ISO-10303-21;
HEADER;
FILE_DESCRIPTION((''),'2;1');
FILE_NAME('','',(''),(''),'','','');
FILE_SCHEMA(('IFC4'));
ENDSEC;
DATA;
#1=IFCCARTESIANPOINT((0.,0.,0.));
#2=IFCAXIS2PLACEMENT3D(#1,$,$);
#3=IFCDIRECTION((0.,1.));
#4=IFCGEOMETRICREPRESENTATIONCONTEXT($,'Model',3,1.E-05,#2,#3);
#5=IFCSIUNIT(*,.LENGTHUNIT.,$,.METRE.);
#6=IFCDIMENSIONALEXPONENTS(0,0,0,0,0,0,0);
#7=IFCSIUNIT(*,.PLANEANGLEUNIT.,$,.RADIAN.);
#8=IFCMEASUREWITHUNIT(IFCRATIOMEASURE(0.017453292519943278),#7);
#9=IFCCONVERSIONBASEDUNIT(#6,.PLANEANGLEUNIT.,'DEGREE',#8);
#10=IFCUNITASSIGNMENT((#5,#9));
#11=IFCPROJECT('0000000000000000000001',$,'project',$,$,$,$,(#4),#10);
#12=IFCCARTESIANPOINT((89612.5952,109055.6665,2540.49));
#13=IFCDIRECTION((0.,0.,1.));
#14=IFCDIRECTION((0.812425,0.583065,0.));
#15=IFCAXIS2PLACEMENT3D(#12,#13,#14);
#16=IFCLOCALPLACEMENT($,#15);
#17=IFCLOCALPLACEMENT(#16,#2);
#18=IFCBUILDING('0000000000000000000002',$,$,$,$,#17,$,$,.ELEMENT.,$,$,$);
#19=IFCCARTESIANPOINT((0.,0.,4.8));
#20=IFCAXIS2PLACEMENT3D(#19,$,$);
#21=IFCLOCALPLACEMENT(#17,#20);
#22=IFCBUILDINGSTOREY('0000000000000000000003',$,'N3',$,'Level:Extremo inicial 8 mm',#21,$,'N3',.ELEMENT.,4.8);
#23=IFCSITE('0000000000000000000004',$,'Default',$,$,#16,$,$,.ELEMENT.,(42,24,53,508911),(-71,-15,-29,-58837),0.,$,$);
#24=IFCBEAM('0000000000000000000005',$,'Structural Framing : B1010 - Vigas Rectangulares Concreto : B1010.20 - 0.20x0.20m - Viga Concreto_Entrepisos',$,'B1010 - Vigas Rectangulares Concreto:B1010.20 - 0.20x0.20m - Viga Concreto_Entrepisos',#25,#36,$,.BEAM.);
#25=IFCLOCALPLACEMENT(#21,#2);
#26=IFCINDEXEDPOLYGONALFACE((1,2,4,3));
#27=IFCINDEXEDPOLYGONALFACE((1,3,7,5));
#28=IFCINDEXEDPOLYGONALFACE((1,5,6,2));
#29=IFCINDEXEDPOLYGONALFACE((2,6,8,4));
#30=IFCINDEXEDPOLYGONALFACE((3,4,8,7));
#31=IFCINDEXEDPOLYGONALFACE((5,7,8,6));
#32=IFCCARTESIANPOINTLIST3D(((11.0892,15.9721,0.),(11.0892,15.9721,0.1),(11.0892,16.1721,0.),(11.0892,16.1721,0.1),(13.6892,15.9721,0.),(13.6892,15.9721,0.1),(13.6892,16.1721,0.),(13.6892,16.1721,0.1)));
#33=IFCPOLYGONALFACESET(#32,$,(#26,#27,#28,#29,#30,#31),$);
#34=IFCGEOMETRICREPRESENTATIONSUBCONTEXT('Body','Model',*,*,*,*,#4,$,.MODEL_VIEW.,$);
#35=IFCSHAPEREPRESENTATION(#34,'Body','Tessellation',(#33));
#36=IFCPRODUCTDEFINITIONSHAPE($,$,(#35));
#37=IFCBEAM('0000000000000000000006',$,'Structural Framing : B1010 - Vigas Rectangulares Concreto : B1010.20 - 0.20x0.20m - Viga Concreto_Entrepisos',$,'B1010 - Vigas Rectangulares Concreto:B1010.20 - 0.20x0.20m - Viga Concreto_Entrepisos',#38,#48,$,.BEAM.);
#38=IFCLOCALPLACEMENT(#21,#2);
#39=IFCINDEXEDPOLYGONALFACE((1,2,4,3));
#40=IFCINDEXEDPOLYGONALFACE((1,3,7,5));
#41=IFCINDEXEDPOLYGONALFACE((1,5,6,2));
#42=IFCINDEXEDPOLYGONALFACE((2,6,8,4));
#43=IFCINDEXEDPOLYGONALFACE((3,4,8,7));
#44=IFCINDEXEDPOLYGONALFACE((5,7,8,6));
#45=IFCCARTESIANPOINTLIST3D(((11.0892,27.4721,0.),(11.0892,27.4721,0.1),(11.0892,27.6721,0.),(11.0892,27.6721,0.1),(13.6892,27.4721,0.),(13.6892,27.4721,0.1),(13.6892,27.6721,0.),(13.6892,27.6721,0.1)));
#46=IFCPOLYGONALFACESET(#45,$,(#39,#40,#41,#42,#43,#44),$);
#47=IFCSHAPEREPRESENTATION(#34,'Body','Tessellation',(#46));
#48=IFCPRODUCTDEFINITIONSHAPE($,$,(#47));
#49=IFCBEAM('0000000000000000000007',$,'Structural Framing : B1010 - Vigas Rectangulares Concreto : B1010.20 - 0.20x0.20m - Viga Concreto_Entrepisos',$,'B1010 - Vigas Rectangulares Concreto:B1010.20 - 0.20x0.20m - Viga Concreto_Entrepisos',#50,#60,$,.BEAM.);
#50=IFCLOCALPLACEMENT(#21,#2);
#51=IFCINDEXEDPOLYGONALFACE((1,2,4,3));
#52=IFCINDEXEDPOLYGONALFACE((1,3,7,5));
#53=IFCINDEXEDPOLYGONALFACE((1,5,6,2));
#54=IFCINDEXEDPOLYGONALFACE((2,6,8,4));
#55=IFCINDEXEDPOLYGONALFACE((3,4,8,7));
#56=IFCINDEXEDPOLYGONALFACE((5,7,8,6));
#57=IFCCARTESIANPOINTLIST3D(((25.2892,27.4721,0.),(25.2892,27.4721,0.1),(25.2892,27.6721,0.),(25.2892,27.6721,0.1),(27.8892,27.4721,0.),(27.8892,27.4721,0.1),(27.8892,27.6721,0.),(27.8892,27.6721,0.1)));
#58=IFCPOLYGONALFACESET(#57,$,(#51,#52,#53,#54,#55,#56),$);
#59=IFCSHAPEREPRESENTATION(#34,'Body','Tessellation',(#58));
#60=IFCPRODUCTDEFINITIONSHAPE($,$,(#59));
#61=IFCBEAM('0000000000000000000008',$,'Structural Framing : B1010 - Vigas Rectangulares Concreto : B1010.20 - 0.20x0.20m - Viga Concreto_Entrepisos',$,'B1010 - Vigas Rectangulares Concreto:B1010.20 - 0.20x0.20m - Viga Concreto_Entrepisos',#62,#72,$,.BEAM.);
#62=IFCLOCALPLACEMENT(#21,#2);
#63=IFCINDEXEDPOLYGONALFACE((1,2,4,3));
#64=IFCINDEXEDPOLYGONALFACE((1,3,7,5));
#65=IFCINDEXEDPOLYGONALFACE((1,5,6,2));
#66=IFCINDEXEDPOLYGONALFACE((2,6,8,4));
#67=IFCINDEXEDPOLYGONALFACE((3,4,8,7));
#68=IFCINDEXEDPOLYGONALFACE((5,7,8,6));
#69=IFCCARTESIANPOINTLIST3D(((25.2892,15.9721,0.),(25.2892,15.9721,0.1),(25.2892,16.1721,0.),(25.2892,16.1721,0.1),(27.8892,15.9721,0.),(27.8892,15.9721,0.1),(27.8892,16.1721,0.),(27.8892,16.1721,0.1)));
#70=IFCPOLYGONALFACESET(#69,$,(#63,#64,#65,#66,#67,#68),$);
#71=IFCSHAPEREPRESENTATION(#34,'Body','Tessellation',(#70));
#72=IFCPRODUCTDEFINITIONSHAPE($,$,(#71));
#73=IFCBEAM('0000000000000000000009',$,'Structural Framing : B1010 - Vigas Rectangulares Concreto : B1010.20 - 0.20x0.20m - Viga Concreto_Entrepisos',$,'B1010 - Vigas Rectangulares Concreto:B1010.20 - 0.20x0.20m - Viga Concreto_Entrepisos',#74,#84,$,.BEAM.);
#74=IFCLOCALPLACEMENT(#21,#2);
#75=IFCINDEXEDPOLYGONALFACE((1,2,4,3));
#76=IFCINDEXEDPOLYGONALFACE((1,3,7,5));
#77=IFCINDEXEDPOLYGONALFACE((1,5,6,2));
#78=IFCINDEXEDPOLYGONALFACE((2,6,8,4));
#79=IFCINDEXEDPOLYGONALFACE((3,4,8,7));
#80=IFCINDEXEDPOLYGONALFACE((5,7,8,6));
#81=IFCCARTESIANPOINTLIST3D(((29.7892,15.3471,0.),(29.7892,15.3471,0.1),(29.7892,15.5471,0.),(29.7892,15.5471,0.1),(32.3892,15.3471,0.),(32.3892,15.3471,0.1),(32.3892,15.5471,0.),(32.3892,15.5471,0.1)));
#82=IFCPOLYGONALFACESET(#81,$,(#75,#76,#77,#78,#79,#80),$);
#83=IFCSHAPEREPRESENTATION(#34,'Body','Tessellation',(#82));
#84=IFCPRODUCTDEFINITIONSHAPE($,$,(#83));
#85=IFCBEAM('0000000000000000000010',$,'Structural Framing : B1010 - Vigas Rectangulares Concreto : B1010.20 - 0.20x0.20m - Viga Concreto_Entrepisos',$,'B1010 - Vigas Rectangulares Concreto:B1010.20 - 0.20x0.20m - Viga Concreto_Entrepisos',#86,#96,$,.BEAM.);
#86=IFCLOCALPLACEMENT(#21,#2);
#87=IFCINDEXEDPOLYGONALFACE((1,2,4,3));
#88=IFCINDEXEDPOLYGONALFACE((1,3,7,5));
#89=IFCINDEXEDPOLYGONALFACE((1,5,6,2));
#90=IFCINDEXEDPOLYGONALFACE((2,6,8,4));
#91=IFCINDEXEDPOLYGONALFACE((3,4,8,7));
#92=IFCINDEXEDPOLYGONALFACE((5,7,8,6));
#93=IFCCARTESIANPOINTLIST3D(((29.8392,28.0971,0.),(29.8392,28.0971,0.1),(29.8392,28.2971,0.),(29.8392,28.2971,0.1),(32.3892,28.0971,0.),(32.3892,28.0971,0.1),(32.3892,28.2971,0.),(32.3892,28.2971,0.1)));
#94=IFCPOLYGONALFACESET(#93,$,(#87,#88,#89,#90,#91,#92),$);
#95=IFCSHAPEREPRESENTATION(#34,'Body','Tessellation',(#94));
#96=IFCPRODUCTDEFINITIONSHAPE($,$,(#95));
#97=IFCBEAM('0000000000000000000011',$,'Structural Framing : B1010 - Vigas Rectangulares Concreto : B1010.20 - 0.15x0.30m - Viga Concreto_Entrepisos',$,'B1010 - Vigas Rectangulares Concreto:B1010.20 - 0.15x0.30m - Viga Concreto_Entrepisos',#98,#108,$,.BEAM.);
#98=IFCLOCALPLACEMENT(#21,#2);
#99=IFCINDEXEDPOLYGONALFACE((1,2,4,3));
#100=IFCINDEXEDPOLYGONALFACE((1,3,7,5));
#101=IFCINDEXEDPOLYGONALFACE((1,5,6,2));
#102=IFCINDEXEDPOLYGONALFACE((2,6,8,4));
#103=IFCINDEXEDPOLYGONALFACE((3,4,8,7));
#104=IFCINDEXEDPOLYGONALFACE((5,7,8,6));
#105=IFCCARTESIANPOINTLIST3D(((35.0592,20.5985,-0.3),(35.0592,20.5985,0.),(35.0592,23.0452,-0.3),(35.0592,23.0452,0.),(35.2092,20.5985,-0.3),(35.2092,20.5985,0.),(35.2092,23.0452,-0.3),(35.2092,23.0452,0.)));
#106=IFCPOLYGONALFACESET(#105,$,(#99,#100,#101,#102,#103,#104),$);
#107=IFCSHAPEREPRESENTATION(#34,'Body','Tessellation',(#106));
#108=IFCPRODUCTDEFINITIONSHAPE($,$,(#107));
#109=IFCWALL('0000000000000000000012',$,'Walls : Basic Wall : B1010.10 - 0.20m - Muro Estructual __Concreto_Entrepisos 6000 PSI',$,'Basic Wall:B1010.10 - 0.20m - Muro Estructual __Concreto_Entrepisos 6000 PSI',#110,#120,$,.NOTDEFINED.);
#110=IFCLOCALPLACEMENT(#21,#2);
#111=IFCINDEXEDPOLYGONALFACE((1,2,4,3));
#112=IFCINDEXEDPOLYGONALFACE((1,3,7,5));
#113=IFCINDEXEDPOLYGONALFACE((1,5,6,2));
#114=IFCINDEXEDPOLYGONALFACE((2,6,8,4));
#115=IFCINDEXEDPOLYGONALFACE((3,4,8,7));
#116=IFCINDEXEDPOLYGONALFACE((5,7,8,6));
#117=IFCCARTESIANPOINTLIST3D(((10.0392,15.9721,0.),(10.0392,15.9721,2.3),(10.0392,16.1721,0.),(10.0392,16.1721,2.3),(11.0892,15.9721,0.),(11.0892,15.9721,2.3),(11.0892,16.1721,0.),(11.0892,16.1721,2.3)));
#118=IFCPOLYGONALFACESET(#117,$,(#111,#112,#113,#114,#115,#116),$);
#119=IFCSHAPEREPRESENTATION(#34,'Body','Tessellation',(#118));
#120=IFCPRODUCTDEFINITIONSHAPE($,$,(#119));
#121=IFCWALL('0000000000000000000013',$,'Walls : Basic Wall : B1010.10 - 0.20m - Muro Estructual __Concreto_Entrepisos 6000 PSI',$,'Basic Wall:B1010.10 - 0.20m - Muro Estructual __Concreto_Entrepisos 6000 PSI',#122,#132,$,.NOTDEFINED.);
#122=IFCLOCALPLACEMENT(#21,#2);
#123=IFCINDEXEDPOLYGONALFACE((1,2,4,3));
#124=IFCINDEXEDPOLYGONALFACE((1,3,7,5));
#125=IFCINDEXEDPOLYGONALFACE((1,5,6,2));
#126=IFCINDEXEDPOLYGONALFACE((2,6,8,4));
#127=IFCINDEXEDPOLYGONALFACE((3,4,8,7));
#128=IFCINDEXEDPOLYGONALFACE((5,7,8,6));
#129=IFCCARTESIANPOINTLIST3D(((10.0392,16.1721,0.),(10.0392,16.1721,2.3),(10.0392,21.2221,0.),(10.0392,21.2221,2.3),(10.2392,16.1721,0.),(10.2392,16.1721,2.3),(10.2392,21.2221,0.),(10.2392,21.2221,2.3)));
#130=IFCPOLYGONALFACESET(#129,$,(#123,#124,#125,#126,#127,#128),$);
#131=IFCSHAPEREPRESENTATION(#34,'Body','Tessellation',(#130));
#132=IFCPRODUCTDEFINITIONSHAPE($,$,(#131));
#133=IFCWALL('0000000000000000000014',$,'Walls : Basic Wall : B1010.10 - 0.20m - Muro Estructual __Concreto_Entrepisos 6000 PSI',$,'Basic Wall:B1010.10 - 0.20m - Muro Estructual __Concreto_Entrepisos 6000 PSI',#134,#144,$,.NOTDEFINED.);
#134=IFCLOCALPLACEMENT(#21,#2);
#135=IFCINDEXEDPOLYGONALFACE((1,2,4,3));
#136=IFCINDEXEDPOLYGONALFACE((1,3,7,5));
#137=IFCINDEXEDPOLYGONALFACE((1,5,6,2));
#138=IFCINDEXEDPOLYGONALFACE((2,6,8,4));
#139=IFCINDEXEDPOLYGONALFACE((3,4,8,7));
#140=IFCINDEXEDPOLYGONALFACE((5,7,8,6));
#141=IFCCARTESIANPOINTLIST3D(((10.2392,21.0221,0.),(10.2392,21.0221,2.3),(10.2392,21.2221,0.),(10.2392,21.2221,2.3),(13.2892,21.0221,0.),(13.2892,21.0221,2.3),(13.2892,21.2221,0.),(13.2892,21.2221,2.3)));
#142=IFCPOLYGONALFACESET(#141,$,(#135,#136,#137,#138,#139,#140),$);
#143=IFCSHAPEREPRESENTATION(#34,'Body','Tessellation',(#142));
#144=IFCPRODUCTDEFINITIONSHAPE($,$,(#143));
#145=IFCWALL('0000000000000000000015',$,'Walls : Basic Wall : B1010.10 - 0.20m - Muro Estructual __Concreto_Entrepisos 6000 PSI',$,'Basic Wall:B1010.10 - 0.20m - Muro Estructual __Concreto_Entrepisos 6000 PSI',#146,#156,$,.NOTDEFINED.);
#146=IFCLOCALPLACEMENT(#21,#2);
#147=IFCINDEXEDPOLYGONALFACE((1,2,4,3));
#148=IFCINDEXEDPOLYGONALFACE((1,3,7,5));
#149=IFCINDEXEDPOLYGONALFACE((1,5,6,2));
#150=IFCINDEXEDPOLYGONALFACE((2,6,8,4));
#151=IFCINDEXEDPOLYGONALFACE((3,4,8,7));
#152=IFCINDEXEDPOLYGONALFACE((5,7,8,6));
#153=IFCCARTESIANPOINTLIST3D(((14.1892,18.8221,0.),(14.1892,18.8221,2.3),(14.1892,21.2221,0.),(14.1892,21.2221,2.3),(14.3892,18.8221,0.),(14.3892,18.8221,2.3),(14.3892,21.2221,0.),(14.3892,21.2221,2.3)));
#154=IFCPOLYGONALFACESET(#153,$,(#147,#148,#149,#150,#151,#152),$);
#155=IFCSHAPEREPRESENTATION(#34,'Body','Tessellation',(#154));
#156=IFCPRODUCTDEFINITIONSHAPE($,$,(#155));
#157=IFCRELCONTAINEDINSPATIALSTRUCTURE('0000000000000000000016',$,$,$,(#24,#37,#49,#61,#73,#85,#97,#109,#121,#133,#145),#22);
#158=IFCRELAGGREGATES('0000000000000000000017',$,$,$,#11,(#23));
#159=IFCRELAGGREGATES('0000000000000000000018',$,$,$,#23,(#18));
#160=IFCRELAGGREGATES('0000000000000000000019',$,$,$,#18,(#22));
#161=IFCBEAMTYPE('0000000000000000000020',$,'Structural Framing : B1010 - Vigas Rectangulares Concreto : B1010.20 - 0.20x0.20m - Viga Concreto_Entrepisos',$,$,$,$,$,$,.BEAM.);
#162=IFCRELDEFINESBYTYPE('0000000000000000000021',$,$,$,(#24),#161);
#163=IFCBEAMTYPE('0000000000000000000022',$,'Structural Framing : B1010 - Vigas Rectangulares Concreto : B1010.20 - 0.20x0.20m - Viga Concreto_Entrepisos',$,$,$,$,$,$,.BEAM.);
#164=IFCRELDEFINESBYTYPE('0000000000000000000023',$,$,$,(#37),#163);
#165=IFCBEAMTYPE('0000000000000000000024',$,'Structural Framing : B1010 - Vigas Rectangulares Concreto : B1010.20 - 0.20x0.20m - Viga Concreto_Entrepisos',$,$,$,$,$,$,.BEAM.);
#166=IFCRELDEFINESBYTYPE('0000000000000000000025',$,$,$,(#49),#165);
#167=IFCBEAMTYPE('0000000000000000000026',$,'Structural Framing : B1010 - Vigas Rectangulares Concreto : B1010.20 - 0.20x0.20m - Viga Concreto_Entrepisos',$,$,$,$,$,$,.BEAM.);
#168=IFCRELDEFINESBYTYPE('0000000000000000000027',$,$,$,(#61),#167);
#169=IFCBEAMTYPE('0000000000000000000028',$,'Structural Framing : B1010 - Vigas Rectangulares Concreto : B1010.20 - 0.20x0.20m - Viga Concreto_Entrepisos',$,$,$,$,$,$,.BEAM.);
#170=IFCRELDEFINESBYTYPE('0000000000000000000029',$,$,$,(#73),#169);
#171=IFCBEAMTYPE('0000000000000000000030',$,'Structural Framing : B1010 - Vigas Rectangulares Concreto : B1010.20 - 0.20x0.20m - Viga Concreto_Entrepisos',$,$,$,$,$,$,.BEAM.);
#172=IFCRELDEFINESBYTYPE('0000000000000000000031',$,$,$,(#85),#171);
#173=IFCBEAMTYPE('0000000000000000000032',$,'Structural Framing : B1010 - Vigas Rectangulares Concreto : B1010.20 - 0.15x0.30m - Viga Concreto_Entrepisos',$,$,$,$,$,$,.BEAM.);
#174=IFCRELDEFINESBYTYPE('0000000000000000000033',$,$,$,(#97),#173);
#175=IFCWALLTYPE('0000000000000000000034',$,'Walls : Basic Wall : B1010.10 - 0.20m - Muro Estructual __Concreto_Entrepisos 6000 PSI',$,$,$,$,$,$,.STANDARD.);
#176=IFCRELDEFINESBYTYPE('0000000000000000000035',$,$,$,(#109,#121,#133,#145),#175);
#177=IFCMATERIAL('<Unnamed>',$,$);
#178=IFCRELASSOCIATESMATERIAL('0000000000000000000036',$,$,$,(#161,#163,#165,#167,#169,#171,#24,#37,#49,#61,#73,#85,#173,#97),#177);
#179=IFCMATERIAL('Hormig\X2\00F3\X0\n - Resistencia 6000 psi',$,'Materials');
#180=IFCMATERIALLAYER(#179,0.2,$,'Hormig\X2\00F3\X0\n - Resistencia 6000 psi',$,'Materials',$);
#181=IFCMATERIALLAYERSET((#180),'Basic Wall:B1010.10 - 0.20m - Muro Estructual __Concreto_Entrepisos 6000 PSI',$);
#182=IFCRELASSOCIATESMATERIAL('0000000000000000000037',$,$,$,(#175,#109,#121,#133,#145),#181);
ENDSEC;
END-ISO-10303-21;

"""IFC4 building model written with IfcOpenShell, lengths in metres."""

from ifc_helpers import new_model, entity, si_unit, converted_unit, direction, frame, frame_2d, origin, place, context, subcontext, project, spatial, polyline, segment, composite_curve, rectangle, outline, extrude, source, transform, mapped, material, layer, layer_set, layer_usage, material_profile, profile_set, profile_usage, type_object, type_shapes, element, save


model = new_model("IFC4")

# Units and contexts
model_context = context("Model", 3, precision=1e-05, world=origin(), true_north=direction((0.0, 1.0)))
body_context = subcontext(model_context, "Body", "Model", "MODEL_VIEW")
ifc_project = project(units=[si_unit("LENGTHUNIT", "METRE"), converted_unit("PLANEANGLEUNIT", "DEGREE", entity("IfcRatioMeasure", 0.017453292519943278), si_unit("PLANEANGLEUNIT", "RADIAN"), dimensions=[0, 0, 0, 0, 0, 0, 0])], contexts=[model_context])

# Site, building, storey
site_placement = place(None, frame((89612.5952, 109055.6665, 2540.49), z_axis=(0.0, 0.0, 1.0), x_axis=(0.812425, 0.583065, 0.0)))
site = spatial("IfcSite", under=ifc_project, at=site_placement, Name="Default", CompositionType="ELEMENT", RefLatitude=(42, 24, 53, 508911), RefLongitude=(-71, -15, -29, -58837), RefElevation=0.0)
building_placement = place(site_placement, origin())
building = spatial("IfcBuilding", under=site, at=building_placement, CompositionType="ELEMENT")
storey_placement = place(building_placement, frame((0.0, 0.0, 4.8)))
storey = spatial("IfcBuildingStorey", under=building, at=storey_placement, Name="N3", ObjectType="Level:Extremo inicial 8 mm", LongName="N3", CompositionType="ELEMENT", Elevation=4.8)

# Beams
ifc_material_1 = material(Name="<Unnamed>")
ifc_material_profile_1 = material_profile(ifc_material_1, outline(composite_curve([segment(polyline([(-0.1, 0.0, 0.0), (-0.1, 0.1, 0.0)]), True, "CONTINUOUS"), segment(polyline([(-0.1, 0.1, 0.0), (0.1, 0.1, 0.0)]), True, "CONTINUOUS"), segment(polyline([(0.1, 0.1, 0.0), (0.1, 0.0, 0.0)]), True, "CONTINUOUS"), segment(polyline([(0.1, 0.0, 0.0), (-0.1, 0.0, 0.0)]), True, "CONTINUOUS")], self_intersect=False), kind="CURVE"), Name="B1010.20 - 0.20x0.20m - Viga Concreto_Entrepisos")
ifc_material_profile_2 = material_profile(ifc_material_1, outline(composite_curve([segment(polyline([(-1.3, -0.1, 0.1), (-1.3, 0.1, 0.1)]), True, "CONTINUOUS"), segment(polyline([(-1.3, 0.1, 0.1), (-1.3, 0.1, -0.1)]), True, "CONTINUOUS"), segment(polyline([(-1.3, 0.1, -0.1), (-1.3, -0.1, -0.1)]), True, "CONTINUOUS"), segment(polyline([(-1.3, -0.1, -0.1), (-1.3, -0.1, 0.1)]), True, "CONTINUOUS")], self_intersect=False), kind="CURVE"), Name="B1010.20 - 0.20x0.20m - Viga Concreto_Entrepisos")
ifc_profile_set_1 = profile_set([ifc_material_profile_1, ifc_material_profile_2], Name="B1010.20 - 0.20x0.20m - Viga Concreto_Entrepisos")
ifc_profile_usage_1 = profile_usage(ifc_profile_set_1, cardinal=8)
beam_type_1 = type_object("IfcBeamType", Name="Structural Framing : B1010 - Vigas Rectangulares Concreto : B1010.20 - 0.20x0.20m - Viga Concreto_Entrepisos", PredefinedType="BEAM", material=ifc_profile_set_1)
shared_shape_1 = source(origin(), body_context, "Body", "SweptSolid", [
    extrude(rectangle(XDim=0.1, YDim=0.2, at=frame_2d((0.0, 0.0), x_axis=(1.0, 0.0))), frame((13.6892, 16.0721, 4.85), z_axis=(-1.0, 0.0, 0.0), x_axis=(0.0, 0.0, -1.0)), (0.0, 0.0, 1.0), 2.6),
])
type_shapes(beam_type_1, [shared_shape_1])
beam_1_placement = place(storey_placement, frame((0.0, 0.0, -4.8)))
element("IfcBeam", 1, at=beam_1_placement, inside=storey, type_object=beam_type_1, material=ifc_profile_usage_1, Name="Structural Framing : B1010 - Vigas Rectangulares Concreto : B1010.20 - 0.20x0.20m - Viga Concreto_Entrepisos", ObjectType="B1010 - Vigas Rectangulares Concreto:B1010.20 - 0.20x0.20m - Viga Concreto_Entrepisos", PredefinedType="BEAM", context=body_context, shape_type="MappedRepresentation", body=[
    mapped(shared_shape_1, transform((0.0, 0.0, 0.0), scale=1.0)),
])
ifc_profile_usage_2 = profile_usage(ifc_profile_set_1, cardinal=8)
beam_type_2 = type_object("IfcBeamType", Name="Structural Framing : B1010 - Vigas Rectangulares Concreto : B1010.20 - 0.20x0.20m - Viga Concreto_Entrepisos", PredefinedType="BEAM", material=ifc_profile_set_1)
shared_shape_2 = source(origin(), body_context, "Body", "SweptSolid", [
    extrude(rectangle(XDim=0.1, YDim=0.2, at=frame_2d((0.0, 0.0), x_axis=(1.0, 0.0))), frame((13.6892, 27.5721, 4.85), z_axis=(-1.0, 0.0, 0.0), x_axis=(0.0, 0.0, -1.0)), (0.0, 0.0, 1.0), 2.6),
])
type_shapes(beam_type_2, [shared_shape_2])
beam_2_placement = place(storey_placement, frame((0.0, 0.0, -4.8)))
element("IfcBeam", 2, at=beam_2_placement, inside=storey, type_object=beam_type_2, material=ifc_profile_usage_2, Name="Structural Framing : B1010 - Vigas Rectangulares Concreto : B1010.20 - 0.20x0.20m - Viga Concreto_Entrepisos", ObjectType="B1010 - Vigas Rectangulares Concreto:B1010.20 - 0.20x0.20m - Viga Concreto_Entrepisos", PredefinedType="BEAM", context=body_context, shape_type="MappedRepresentation", body=[
    mapped(shared_shape_2, transform((0.0, 0.0, 0.0), scale=1.0)),
])
ifc_profile_usage_3 = profile_usage(ifc_profile_set_1, cardinal=8)
beam_type_3 = type_object("IfcBeamType", Name="Structural Framing : B1010 - Vigas Rectangulares Concreto : B1010.20 - 0.20x0.20m - Viga Concreto_Entrepisos", PredefinedType="BEAM", material=ifc_profile_set_1)
shared_shape_3 = source(origin(), body_context, "Body", "SweptSolid", [
    extrude(rectangle(XDim=0.1, YDim=0.2, at=frame_2d((0.0, 0.0), x_axis=(1.0, 0.0))), frame((25.2892, 27.5721, 4.85), z_axis=(1.0, 0.0, 0.0), x_axis=(0.0, 0.0, -1.0)), (0.0, 0.0, 1.0), 2.6),
])
type_shapes(beam_type_3, [shared_shape_3])
beam_3_placement = place(storey_placement, frame((0.0, 0.0, -4.8)))
element("IfcBeam", 3, at=beam_3_placement, inside=storey, type_object=beam_type_3, material=ifc_profile_usage_3, Name="Structural Framing : B1010 - Vigas Rectangulares Concreto : B1010.20 - 0.20x0.20m - Viga Concreto_Entrepisos", ObjectType="B1010 - Vigas Rectangulares Concreto:B1010.20 - 0.20x0.20m - Viga Concreto_Entrepisos", PredefinedType="BEAM", context=body_context, shape_type="MappedRepresentation", body=[
    mapped(shared_shape_3, transform((0.0, 0.0, 0.0), scale=1.0)),
])
ifc_profile_usage_4 = profile_usage(ifc_profile_set_1, cardinal=8)
beam_type_4 = type_object("IfcBeamType", Name="Structural Framing : B1010 - Vigas Rectangulares Concreto : B1010.20 - 0.20x0.20m - Viga Concreto_Entrepisos", PredefinedType="BEAM", material=ifc_profile_set_1)
shared_shape_4 = source(origin(), body_context, "Body", "SweptSolid", [
    extrude(rectangle(XDim=0.1, YDim=0.2, at=frame_2d((0.0, 0.0), x_axis=(1.0, 0.0))), frame((25.2892, 16.0721, 4.85), z_axis=(1.0, 0.0, 0.0), x_axis=(0.0, 0.0, -1.0)), (0.0, 0.0, 1.0), 2.6),
])
type_shapes(beam_type_4, [shared_shape_4])
beam_4_placement = place(storey_placement, frame((0.0, 0.0, -4.8)))
element("IfcBeam", 4, at=beam_4_placement, inside=storey, type_object=beam_type_4, material=ifc_profile_usage_4, Name="Structural Framing : B1010 - Vigas Rectangulares Concreto : B1010.20 - 0.20x0.20m - Viga Concreto_Entrepisos", ObjectType="B1010 - Vigas Rectangulares Concreto:B1010.20 - 0.20x0.20m - Viga Concreto_Entrepisos", PredefinedType="BEAM", context=body_context, shape_type="MappedRepresentation", body=[
    mapped(shared_shape_4, transform((0.0, 0.0, 0.0), scale=1.0)),
])
ifc_profile_usage_5 = profile_usage(ifc_profile_set_1, cardinal=8)
beam_type_5 = type_object("IfcBeamType", Name="Structural Framing : B1010 - Vigas Rectangulares Concreto : B1010.20 - 0.20x0.20m - Viga Concreto_Entrepisos", PredefinedType="BEAM", material=ifc_profile_set_1)
shared_shape_5 = source(origin(), body_context, "Body", "SweptSolid", [
    extrude(rectangle(XDim=0.1, YDim=0.2, at=frame_2d((0.0, 0.0), x_axis=(1.0, 0.0))), frame((32.3892, 15.4471, 4.85), z_axis=(-1.0, 0.0, 0.0), x_axis=(0.0, 0.0, -1.0)), (0.0, 0.0, 1.0), 2.6),
])
type_shapes(beam_type_5, [shared_shape_5])
beam_5_placement = place(storey_placement, frame((0.0, 0.0, -4.8)))
element("IfcBeam", 5, at=beam_5_placement, inside=storey, type_object=beam_type_5, material=ifc_profile_usage_5, Name="Structural Framing : B1010 - Vigas Rectangulares Concreto : B1010.20 - 0.20x0.20m - Viga Concreto_Entrepisos", ObjectType="B1010 - Vigas Rectangulares Concreto:B1010.20 - 0.20x0.20m - Viga Concreto_Entrepisos", PredefinedType="BEAM", context=body_context, shape_type="MappedRepresentation", body=[
    mapped(shared_shape_5, transform((0.0, 0.0, 0.0), scale=1.0)),
])
ifc_profile_usage_6 = profile_usage(ifc_profile_set_1, cardinal=8)
beam_type_6 = type_object("IfcBeamType", Name="Structural Framing : B1010 - Vigas Rectangulares Concreto : B1010.20 - 0.20x0.20m - Viga Concreto_Entrepisos", PredefinedType="BEAM", material=ifc_profile_set_1)
shared_shape_6 = source(origin(), body_context, "Body", "SweptSolid", [
    extrude(rectangle(XDim=0.1, YDim=0.2, at=frame_2d((0.0, 0.0), x_axis=(1.0, 0.0))), frame((29.8392, 28.1971, 4.85), z_axis=(1.0, 0.0, 0.0), x_axis=(0.0, 0.0, -1.0)), (0.0, 0.0, 1.0), 2.55),
])
type_shapes(beam_type_6, [shared_shape_6])
beam_6_placement = place(storey_placement, frame((0.0, 0.0, -4.8)))
element("IfcBeam", 6, at=beam_6_placement, inside=storey, type_object=beam_type_6, material=ifc_profile_usage_6, Name="Structural Framing : B1010 - Vigas Rectangulares Concreto : B1010.20 - 0.20x0.20m - Viga Concreto_Entrepisos", ObjectType="B1010 - Vigas Rectangulares Concreto:B1010.20 - 0.20x0.20m - Viga Concreto_Entrepisos", PredefinedType="BEAM", context=body_context, shape_type="MappedRepresentation", body=[
    mapped(shared_shape_6, transform((0.0, 0.0, 0.0), scale=1.0)),
])
ifc_material_profile_3 = material_profile(ifc_material_1, outline(composite_curve([segment(polyline([(-0.075, -0.15, 0.0), (-0.075, 0.15, 0.0)]), True, "CONTINUOUS"), segment(polyline([(-0.075, 0.15, 0.0), (0.075, 0.15, 0.0)]), True, "CONTINUOUS"), segment(polyline([(0.075, 0.15, 0.0), (0.075, -0.15, 0.0)]), True, "CONTINUOUS"), segment(polyline([(0.075, -0.15, 0.0), (-0.075, -0.15, 0.0)]), True, "CONTINUOUS")], self_intersect=False), kind="CURVE"), Name="B1010.20 - 0.15x0.30m - Viga Concreto_Entrepisos")
ifc_material_profile_4 = material_profile(ifc_material_1, outline(composite_curve([segment(polyline([(1.2233, 0.075, 0.15), (1.2233, 0.075, -0.15)]), True, "CONTINUOUS"), segment(polyline([(1.2233, 0.075, -0.15), (-1.2233, 0.075, -0.15)]), True, "CONTINUOUS"), segment(polyline([(-1.2233, 0.075, -0.15), (-1.2233, 0.075, 0.15)]), True, "CONTINUOUS"), segment(polyline([(-1.2233, 0.075, 0.15), (1.2233, 0.075, 0.15)]), True, "CONTINUOUS")], self_intersect=False), kind="CURVE"), Name="B1010.20 - 0.15x0.30m - Viga Concreto_Entrepisos")
ifc_profile_set_2 = profile_set([ifc_material_profile_3, ifc_material_profile_4], Name="B1010.20 - 0.15x0.30m - Viga Concreto_Entrepisos")
ifc_profile_usage_7 = profile_usage(ifc_profile_set_2, cardinal=8)
beam_type_7 = type_object("IfcBeamType", Name="Structural Framing : B1010 - Vigas Rectangulares Concreto : B1010.20 - 0.15x0.30m - Viga Concreto_Entrepisos", PredefinedType="BEAM", material=ifc_profile_set_2)
shared_shape_7 = source(origin(), body_context, "Body", "SweptSolid", [
    extrude(rectangle(XDim=0.3, YDim=0.15, at=frame_2d((0.0, 0.0), x_axis=(0.0, 1.0))), frame((35.1342, 20.5985, 4.65), z_axis=(0.0, 1.0, 0.0), x_axis=(-1.0, 0.0, 0.0)), (0.0, 0.0, 1.0), 2.4467),
])
type_shapes(beam_type_7, [shared_shape_7])
beam_7_placement = place(storey_placement, frame((0.0, 0.0, -4.8)))
element("IfcBeam", 7, at=beam_7_placement, inside=storey, type_object=beam_type_7, material=ifc_profile_usage_7, Name="Structural Framing : B1010 - Vigas Rectangulares Concreto : B1010.20 - 0.15x0.30m - Viga Concreto_Entrepisos", ObjectType="B1010 - Vigas Rectangulares Concreto:B1010.20 - 0.15x0.30m - Viga Concreto_Entrepisos", PredefinedType="BEAM", context=body_context, shape_type="MappedRepresentation", body=[
    mapped(shared_shape_7, transform((0.0, 0.0, 0.0), scale=1.0)),
])

# Walls
ifc_material_2 = material(Name="Hormigón - Resistencia 6000 psi", Category="Materials")
ifc_layer_1 = layer(ifc_material_2, 0.2, Name="Hormigón - Resistencia 6000 psi", Category="Materials")
ifc_layer_set_1 = layer_set([ifc_layer_1], Name="Basic Wall:B1010.10 - 0.20m - Muro Estructual __Concreto_Entrepisos 6000 PSI")
ifc_layer_usage_1 = layer_usage(ifc_layer_set_1, "AXIS2", "NEGATIVE", 0.1)
wall_type_1 = type_object("IfcWallType", Name="Walls : Basic Wall : B1010.10 - 0.20m - Muro Estructual __Concreto_Entrepisos 6000 PSI", PredefinedType="STANDARD", material=ifc_layer_set_1)
wall_1_placement = place(storey_placement, frame((11.0892, 16.0721, 0.0), z_axis=(0.0, 0.0, 1.0), x_axis=(-1.0, 0.0, 0.0)))
element("IfcWall", 8, at=wall_1_placement, inside=storey, type_object=wall_type_1, material=ifc_layer_usage_1, Name="Walls : Basic Wall : B1010.10 - 0.20m - Muro Estructual __Concreto_Entrepisos 6000 PSI", ObjectType="Basic Wall:B1010.10 - 0.20m - Muro Estructual __Concreto_Entrepisos 6000 PSI", PredefinedType="NOTDEFINED", context=body_context, shape_type="SweptSolid", body=[
    extrude(rectangle(XDim=1.05, YDim=0.2, at=frame_2d((0.525, 0.0), x_axis=(-1.0, 0.0))), origin(), (0.0, 0.0, 1.0), 2.3),
])
ifc_layer_usage_2 = layer_usage(ifc_layer_set_1, "AXIS2", "NEGATIVE", 0.1)
wall_2_placement = place(storey_placement, frame((10.1392, 16.1721, 0.0), z_axis=(0.0, 0.0, 1.0), x_axis=(0.0, 1.0, 0.0)))
element("IfcWall", 9, at=wall_2_placement, inside=storey, type_object=wall_type_1, material=ifc_layer_usage_2, Name="Walls : Basic Wall : B1010.10 - 0.20m - Muro Estructual __Concreto_Entrepisos 6000 PSI", ObjectType="Basic Wall:B1010.10 - 0.20m - Muro Estructual __Concreto_Entrepisos 6000 PSI", PredefinedType="NOTDEFINED", context=body_context, shape_type="SweptSolid", body=[
    extrude(rectangle(XDim=5.05, YDim=0.2, at=frame_2d((2.525, 0.0), x_axis=(-1.0, 0.0))), origin(), (0.0, 0.0, 1.0), 2.3),
])
ifc_layer_usage_3 = layer_usage(ifc_layer_set_1, "AXIS2", "NEGATIVE", 0.1)
wall_3_placement = place(storey_placement, frame((10.2392, 21.1221, 0.0)))
element("IfcWall", 10, at=wall_3_placement, inside=storey, type_object=wall_type_1, material=ifc_layer_usage_3, Name="Walls : Basic Wall : B1010.10 - 0.20m - Muro Estructual __Concreto_Entrepisos 6000 PSI", ObjectType="Basic Wall:B1010.10 - 0.20m - Muro Estructual __Concreto_Entrepisos 6000 PSI", PredefinedType="NOTDEFINED", context=body_context, shape_type="SweptSolid", body=[
    extrude(rectangle(XDim=3.05, YDim=0.2, at=frame_2d((1.525, 0.0), x_axis=(-1.0, 0.0))), origin(), (0.0, 0.0, 1.0), 2.3),
])
ifc_layer_usage_4 = layer_usage(ifc_layer_set_1, "AXIS2", "NEGATIVE", 0.1)
wall_4_placement = place(storey_placement, frame((14.2892, 18.8221, 0.0), z_axis=(0.0, 0.0, 1.0), x_axis=(0.0, 1.0, 0.0)))
element("IfcWall", 11, at=wall_4_placement, inside=storey, type_object=wall_type_1, material=ifc_layer_usage_4, Name="Walls : Basic Wall : B1010.10 - 0.20m - Muro Estructual __Concreto_Entrepisos 6000 PSI", ObjectType="Basic Wall:B1010.10 - 0.20m - Muro Estructual __Concreto_Entrepisos 6000 PSI", PredefinedType="NOTDEFINED", context=body_context, shape_type="SweptSolid", body=[
    extrude(rectangle(XDim=2.4, YDim=0.2, at=frame_2d((1.2, 0.0), x_axis=(-1.0, 0.0))), origin(), (0.0, 0.0, 1.0), 2.3),
])

save(model, "model.ifc")
